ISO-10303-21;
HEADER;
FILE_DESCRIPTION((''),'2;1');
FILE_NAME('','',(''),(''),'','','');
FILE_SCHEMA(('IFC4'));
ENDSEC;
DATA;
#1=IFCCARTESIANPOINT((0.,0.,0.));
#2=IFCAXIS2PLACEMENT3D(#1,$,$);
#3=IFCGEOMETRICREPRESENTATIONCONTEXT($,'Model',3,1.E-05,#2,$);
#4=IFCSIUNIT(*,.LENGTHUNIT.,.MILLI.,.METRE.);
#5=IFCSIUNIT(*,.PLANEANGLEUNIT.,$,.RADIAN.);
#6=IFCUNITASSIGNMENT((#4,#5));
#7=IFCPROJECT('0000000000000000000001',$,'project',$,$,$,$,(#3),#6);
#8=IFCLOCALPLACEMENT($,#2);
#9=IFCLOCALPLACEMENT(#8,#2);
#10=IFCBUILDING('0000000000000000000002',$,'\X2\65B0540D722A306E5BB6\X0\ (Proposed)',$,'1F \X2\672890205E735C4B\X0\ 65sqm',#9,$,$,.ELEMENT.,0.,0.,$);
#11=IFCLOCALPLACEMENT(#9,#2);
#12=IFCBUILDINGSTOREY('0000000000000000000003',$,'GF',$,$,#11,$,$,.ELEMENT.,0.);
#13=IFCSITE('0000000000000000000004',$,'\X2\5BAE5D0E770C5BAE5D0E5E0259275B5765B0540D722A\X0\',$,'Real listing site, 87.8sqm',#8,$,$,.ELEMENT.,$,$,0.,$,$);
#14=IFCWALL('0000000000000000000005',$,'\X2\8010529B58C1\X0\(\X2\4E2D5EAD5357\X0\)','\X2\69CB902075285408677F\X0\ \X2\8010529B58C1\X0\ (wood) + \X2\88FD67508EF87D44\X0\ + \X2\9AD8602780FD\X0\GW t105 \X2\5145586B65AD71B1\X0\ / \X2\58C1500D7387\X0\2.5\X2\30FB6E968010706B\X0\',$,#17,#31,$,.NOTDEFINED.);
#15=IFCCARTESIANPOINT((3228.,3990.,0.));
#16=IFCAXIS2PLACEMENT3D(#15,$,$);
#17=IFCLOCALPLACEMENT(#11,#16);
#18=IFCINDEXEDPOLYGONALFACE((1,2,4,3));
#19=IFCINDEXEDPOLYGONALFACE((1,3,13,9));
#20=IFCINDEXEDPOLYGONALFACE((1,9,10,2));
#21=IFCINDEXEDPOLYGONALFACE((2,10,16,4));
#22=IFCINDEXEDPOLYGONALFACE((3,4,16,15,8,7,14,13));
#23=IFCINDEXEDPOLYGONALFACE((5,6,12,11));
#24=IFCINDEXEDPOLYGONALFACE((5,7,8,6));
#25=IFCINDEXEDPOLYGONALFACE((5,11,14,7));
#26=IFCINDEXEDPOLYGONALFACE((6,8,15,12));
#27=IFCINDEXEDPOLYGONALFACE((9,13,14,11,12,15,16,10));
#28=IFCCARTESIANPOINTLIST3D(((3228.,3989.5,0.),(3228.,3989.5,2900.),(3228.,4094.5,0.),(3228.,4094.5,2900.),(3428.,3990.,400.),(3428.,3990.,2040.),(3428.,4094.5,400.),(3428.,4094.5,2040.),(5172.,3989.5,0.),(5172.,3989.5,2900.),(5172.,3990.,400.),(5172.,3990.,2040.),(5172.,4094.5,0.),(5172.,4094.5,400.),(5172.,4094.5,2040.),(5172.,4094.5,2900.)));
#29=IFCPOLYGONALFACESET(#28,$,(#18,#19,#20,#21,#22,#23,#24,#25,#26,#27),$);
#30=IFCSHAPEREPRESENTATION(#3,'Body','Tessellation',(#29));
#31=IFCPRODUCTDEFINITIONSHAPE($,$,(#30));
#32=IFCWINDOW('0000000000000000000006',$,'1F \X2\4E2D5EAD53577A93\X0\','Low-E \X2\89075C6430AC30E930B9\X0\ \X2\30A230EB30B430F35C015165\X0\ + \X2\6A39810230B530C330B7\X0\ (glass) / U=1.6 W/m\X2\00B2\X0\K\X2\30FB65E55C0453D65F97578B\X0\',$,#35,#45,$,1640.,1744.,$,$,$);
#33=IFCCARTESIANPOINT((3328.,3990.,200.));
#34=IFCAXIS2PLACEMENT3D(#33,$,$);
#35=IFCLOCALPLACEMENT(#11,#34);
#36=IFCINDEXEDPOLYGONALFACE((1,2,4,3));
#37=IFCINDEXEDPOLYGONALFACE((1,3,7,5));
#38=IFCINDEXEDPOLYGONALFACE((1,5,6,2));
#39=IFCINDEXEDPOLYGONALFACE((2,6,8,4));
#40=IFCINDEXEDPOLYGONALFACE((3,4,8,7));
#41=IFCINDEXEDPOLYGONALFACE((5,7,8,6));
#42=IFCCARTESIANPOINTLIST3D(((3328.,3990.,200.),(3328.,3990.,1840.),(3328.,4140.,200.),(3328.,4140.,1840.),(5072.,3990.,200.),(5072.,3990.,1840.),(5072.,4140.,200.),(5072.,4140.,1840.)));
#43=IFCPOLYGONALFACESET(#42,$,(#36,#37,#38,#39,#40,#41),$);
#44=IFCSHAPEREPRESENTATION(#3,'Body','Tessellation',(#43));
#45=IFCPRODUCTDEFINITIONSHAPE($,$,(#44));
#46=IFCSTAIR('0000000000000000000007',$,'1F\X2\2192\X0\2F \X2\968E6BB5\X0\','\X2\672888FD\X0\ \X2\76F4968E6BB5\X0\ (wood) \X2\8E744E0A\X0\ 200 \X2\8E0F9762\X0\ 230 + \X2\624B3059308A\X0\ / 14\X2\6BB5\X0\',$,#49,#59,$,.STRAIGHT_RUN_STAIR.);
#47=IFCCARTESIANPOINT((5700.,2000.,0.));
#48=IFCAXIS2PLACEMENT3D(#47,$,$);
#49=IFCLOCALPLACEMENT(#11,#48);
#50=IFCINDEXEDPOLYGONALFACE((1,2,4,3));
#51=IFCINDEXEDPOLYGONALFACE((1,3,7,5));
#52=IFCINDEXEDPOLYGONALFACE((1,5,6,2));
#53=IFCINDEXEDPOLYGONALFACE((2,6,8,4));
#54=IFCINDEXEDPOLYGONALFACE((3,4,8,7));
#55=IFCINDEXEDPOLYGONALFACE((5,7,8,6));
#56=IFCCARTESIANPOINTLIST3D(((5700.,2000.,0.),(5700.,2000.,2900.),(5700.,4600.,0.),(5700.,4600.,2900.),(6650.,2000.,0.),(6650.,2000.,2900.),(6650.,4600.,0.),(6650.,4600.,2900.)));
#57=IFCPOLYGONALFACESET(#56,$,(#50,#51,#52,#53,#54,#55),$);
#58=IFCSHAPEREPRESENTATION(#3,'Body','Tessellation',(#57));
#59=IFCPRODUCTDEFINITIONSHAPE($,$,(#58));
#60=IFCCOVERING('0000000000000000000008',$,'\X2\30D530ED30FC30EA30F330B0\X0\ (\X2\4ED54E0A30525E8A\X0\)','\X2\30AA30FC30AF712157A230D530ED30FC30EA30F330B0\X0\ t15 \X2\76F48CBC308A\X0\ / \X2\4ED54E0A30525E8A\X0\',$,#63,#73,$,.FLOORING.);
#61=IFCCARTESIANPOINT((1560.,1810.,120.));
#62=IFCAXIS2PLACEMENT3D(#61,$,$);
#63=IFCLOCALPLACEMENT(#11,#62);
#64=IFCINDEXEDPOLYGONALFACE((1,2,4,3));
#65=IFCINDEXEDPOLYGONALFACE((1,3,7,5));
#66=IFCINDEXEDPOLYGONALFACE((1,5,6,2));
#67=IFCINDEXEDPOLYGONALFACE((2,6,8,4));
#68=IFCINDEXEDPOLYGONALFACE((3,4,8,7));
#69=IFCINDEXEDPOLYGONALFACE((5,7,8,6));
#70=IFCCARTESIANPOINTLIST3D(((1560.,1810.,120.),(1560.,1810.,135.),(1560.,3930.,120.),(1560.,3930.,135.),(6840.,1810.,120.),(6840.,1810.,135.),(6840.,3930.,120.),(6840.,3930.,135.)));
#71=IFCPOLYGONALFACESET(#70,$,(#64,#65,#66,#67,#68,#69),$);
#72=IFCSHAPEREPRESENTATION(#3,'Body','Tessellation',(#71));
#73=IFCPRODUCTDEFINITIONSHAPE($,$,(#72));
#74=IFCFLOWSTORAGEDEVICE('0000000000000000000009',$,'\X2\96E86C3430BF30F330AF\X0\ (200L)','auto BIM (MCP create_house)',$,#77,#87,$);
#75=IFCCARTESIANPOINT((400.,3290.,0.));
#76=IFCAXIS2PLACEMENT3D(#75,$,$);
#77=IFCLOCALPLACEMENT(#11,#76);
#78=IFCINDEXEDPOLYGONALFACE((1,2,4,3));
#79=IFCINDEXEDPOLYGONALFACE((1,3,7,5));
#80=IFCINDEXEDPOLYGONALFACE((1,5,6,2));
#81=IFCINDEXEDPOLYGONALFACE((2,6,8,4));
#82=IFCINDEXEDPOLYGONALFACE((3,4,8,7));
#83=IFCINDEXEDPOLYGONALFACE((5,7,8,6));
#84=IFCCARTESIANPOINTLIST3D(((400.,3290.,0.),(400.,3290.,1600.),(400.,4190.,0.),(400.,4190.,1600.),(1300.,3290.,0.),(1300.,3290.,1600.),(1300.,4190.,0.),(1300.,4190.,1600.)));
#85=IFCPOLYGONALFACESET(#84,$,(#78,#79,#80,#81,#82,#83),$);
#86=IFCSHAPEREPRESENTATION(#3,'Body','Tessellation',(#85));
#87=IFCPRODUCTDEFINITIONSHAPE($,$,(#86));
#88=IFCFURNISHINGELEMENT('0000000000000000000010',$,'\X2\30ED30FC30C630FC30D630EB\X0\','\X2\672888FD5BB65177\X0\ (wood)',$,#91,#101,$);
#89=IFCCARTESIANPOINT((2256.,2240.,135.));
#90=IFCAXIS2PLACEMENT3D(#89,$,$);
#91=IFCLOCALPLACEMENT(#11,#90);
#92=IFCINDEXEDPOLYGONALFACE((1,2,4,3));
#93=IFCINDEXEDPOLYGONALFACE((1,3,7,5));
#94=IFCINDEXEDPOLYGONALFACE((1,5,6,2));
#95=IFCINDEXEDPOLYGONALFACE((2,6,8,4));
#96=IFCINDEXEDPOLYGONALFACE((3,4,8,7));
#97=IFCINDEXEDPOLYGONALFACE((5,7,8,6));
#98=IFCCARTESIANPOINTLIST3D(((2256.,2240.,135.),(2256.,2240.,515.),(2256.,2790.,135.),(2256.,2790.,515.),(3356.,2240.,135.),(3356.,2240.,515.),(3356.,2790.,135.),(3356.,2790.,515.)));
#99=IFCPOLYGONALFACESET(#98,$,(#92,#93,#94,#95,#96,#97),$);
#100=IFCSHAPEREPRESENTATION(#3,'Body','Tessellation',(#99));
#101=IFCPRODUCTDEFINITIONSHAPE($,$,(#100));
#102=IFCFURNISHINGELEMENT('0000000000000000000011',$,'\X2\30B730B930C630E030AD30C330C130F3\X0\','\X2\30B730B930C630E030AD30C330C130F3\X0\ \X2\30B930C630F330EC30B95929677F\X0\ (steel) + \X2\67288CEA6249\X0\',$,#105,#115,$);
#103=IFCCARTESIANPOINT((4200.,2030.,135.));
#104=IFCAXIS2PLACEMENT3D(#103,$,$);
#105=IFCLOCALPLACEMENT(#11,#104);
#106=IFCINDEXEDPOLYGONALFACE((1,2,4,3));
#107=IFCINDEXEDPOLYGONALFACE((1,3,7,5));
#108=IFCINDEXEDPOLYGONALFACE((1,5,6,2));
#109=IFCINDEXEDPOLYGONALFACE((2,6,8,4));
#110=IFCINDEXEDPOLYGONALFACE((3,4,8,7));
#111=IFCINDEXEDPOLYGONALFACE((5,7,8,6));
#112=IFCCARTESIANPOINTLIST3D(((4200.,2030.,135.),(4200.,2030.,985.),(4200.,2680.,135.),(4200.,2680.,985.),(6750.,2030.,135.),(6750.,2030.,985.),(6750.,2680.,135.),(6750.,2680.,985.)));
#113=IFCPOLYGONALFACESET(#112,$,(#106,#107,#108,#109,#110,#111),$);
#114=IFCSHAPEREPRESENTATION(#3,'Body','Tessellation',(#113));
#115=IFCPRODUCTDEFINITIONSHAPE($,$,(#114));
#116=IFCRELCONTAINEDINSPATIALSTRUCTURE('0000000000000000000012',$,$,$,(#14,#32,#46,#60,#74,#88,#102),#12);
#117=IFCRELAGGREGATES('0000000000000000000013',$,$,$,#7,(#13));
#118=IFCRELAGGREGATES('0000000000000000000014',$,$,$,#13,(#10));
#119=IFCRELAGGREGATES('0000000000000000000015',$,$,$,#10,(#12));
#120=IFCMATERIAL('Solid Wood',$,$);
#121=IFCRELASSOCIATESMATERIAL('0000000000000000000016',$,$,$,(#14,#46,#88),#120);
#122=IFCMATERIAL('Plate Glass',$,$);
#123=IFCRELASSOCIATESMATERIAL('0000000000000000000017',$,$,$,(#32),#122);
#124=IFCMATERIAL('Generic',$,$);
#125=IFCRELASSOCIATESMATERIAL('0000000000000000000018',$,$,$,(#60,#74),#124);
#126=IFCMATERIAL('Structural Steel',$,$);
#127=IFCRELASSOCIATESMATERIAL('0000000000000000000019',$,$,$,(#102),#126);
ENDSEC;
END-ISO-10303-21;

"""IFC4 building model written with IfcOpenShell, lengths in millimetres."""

from ifc_helpers import new_model, si_unit, frame, frame_2d, origin, place, context, project, spatial, rectangle, extrude, material, element, fill, save


model = new_model("IFC4")

# Units and contexts
model_context = context("Model", 3, precision=1e-05, world=origin())
ifc_project = project(units=[si_unit("LENGTHUNIT", "METRE", prefix="MILLI"), si_unit("PLANEANGLEUNIT", "RADIAN")], contexts=[model_context])

# Site, building, storey
site_placement = place(None, origin())
site = spatial("IfcSite", under=ifc_project, at=site_placement, Name="宮崎県宮崎市大字新名爪", ObjectType="Real listing site, 87.8sqm", CompositionType="ELEMENT", RefElevation=0.0)
building_placement = place(site_placement, origin())
building = spatial("IfcBuilding", under=site, at=building_placement, Name="新名爪の家 (Proposed)", ObjectType="1F 木造平屋 65sqm", CompositionType="ELEMENT", ElevationOfRefHeight=0.0, ElevationOfTerrain=0.0)
storey_placement = place(building_placement, origin())
storey = spatial("IfcBuildingStorey", under=building, at=storey_placement, Name="GF", CompositionType="ELEMENT", Elevation=0.0)

# Shared definitions
ifc_material_1 = material(Name="Solid Wood")

# Shared definitions
ifc_material_2 = material(Name="Plate Glass")

# Wall, opening, window
wall_1_placement = place(storey_placement, frame((3228.0, 3990.0, 0.0)))
wall_1 = element("IfcWall", 1, at=wall_1_placement, inside=storey, material=ifc_material_1, Name="耐力壁(中庭南)", Description="構造用合板 耐力壁 (wood) + 製材軸組 + 高性能GW t105 充填断熱 / 壁倍率2.5・準耐火", PredefinedType="NOTDEFINED", context=model_context, shape_type="SweptSolid", body=[
    extrude(rectangle(XDim=1944.0, YDim=105.0, at=frame_2d((972.0, 52.0))), frame((3228.0, 3990.0, 0.0)), (0.0, 0.0, 1.0), 2900.0),
])
opening_1_placement = place(storey_placement, frame((3328.0, 3990.0, 200.0)))
opening_1 = element("IfcOpeningElement", 2, at=opening_1_placement, cuts=wall_1, PredefinedType="NOTDEFINED", context=model_context, shape_type="SweptSolid", body=[
    extrude(rectangle(XDim=1744.0, YDim=150.0, at=frame_2d((872.0, 75.0))), frame((3328.0, 3990.0, 200.0)), (0.0, 0.0, 1.0), 1640.0),
])
window_1_placement = place(storey_placement, frame((3328.0, 3990.0, 200.0)))
window_1 = element("IfcWindow", 3, at=window_1_placement, inside=storey, material=ifc_material_2, Name="1F 中庭南窓", Description="Low-E 複層ガラス アルゴン封入 + 樹脂サッシ (glass) / U=1.6 W/m²K・日射取得型", OverallHeight=1640.0, OverallWidth=1744.0, context=model_context, shape_type="SweptSolid", body=[
    extrude(rectangle(XDim=1744.0, YDim=150.0, at=frame_2d((872.0, 75.0))), frame((3328.0, 3990.0, 200.0)), (0.0, 0.0, 1.0), 1640.0),
])
fill(opening_1, window_1)

# Stair
stair_placement = place(storey_placement, frame((5700.0, 2000.0, 0.0)))
element("IfcStair", 4, at=stair_placement, inside=storey, material=ifc_material_1, Name="1F→2F 階段", Description="木製 直階段 (wood) 蹴上 200 踏面 230 + 手すり / 14段", PredefinedType="STRAIGHT_RUN_STAIR", context=model_context, shape_type="SweptSolid", body=[
    extrude(rectangle(XDim=950.0, YDim=2600.0, at=frame_2d((475.0, 1300.0))), frame((5700.0, 2000.0, 0.0)), (0.0, 0.0, 1.0), 2900.0),
])

# Covering
ifc_material_3 = material(Name="Generic")
covering_placement = place(storey_placement, frame((1560.0, 1810.0, 120.0)))
element("IfcCovering", 5, at=covering_placement, inside=storey, material=ifc_material_3, Name="フローリング (仕上げ床)", Description="オーク無垢フローリング t15 直貼り / 仕上げ床", PredefinedType="FLOORING", context=model_context, shape_type="SweptSolid", body=[
    extrude(rectangle(XDim=5280.0, YDim=2120.0, at=frame_2d((2640.0, 1060.0))), frame((1560.0, 1810.0, 120.0)), (0.0, 0.0, 1.0), 15.0),
])

# Flow storage device
flow_storage_device_placement = place(storey_placement, frame((400.0, 3290.0, 0.0)))
element("IfcFlowStorageDevice", 6, at=flow_storage_device_placement, inside=storey, material=ifc_material_3, Name="雨水タンク (200L)", Description="auto BIM (MCP create_house)", context=model_context, shape_type="SweptSolid", body=[
    extrude(rectangle(XDim=900.0, YDim=900.0, at=frame_2d((450.0, 450.0))), frame((400.0, 3290.0, 0.0)), (0.0, 0.0, 1.0), 1600.0),
])

# Furnishing elements
furnishing_1_placement = place(storey_placement, frame((2256.0, 2240.0, 135.0)))
element("IfcFurnishingElement", 7, at=furnishing_1_placement, inside=storey, material=ifc_material_1, Name="ローテーブル", Description="木製家具 (wood)", context=model_context, shape_type="SweptSolid", body=[
    extrude(rectangle(XDim=1100.0, YDim=550.0, at=frame_2d((550.0, 275.0))), frame((2256.0, 2240.0, 135.0)), (0.0, 0.0, 1.0), 380.0),
])
ifc_material_4 = material(Name="Structural Steel")
furnishing_2_placement = place(storey_placement, frame((4200.0, 2030.0, 135.0)))
element("IfcFurnishingElement", 8, at=furnishing_2_placement, inside=storey, material=ifc_material_4, Name="システムキッチン", Description="システムキッチン ステンレス天板 (steel) + 木質扉", context=model_context, shape_type="SweptSolid", body=[
    extrude(rectangle(XDim=2550.0, YDim=650.0, at=frame_2d((1275.0, 325.0))), frame((4200.0, 2030.0, 135.0)), (0.0, 0.0, 1.0), 850.0),
])

save(model, "model.ifc")
